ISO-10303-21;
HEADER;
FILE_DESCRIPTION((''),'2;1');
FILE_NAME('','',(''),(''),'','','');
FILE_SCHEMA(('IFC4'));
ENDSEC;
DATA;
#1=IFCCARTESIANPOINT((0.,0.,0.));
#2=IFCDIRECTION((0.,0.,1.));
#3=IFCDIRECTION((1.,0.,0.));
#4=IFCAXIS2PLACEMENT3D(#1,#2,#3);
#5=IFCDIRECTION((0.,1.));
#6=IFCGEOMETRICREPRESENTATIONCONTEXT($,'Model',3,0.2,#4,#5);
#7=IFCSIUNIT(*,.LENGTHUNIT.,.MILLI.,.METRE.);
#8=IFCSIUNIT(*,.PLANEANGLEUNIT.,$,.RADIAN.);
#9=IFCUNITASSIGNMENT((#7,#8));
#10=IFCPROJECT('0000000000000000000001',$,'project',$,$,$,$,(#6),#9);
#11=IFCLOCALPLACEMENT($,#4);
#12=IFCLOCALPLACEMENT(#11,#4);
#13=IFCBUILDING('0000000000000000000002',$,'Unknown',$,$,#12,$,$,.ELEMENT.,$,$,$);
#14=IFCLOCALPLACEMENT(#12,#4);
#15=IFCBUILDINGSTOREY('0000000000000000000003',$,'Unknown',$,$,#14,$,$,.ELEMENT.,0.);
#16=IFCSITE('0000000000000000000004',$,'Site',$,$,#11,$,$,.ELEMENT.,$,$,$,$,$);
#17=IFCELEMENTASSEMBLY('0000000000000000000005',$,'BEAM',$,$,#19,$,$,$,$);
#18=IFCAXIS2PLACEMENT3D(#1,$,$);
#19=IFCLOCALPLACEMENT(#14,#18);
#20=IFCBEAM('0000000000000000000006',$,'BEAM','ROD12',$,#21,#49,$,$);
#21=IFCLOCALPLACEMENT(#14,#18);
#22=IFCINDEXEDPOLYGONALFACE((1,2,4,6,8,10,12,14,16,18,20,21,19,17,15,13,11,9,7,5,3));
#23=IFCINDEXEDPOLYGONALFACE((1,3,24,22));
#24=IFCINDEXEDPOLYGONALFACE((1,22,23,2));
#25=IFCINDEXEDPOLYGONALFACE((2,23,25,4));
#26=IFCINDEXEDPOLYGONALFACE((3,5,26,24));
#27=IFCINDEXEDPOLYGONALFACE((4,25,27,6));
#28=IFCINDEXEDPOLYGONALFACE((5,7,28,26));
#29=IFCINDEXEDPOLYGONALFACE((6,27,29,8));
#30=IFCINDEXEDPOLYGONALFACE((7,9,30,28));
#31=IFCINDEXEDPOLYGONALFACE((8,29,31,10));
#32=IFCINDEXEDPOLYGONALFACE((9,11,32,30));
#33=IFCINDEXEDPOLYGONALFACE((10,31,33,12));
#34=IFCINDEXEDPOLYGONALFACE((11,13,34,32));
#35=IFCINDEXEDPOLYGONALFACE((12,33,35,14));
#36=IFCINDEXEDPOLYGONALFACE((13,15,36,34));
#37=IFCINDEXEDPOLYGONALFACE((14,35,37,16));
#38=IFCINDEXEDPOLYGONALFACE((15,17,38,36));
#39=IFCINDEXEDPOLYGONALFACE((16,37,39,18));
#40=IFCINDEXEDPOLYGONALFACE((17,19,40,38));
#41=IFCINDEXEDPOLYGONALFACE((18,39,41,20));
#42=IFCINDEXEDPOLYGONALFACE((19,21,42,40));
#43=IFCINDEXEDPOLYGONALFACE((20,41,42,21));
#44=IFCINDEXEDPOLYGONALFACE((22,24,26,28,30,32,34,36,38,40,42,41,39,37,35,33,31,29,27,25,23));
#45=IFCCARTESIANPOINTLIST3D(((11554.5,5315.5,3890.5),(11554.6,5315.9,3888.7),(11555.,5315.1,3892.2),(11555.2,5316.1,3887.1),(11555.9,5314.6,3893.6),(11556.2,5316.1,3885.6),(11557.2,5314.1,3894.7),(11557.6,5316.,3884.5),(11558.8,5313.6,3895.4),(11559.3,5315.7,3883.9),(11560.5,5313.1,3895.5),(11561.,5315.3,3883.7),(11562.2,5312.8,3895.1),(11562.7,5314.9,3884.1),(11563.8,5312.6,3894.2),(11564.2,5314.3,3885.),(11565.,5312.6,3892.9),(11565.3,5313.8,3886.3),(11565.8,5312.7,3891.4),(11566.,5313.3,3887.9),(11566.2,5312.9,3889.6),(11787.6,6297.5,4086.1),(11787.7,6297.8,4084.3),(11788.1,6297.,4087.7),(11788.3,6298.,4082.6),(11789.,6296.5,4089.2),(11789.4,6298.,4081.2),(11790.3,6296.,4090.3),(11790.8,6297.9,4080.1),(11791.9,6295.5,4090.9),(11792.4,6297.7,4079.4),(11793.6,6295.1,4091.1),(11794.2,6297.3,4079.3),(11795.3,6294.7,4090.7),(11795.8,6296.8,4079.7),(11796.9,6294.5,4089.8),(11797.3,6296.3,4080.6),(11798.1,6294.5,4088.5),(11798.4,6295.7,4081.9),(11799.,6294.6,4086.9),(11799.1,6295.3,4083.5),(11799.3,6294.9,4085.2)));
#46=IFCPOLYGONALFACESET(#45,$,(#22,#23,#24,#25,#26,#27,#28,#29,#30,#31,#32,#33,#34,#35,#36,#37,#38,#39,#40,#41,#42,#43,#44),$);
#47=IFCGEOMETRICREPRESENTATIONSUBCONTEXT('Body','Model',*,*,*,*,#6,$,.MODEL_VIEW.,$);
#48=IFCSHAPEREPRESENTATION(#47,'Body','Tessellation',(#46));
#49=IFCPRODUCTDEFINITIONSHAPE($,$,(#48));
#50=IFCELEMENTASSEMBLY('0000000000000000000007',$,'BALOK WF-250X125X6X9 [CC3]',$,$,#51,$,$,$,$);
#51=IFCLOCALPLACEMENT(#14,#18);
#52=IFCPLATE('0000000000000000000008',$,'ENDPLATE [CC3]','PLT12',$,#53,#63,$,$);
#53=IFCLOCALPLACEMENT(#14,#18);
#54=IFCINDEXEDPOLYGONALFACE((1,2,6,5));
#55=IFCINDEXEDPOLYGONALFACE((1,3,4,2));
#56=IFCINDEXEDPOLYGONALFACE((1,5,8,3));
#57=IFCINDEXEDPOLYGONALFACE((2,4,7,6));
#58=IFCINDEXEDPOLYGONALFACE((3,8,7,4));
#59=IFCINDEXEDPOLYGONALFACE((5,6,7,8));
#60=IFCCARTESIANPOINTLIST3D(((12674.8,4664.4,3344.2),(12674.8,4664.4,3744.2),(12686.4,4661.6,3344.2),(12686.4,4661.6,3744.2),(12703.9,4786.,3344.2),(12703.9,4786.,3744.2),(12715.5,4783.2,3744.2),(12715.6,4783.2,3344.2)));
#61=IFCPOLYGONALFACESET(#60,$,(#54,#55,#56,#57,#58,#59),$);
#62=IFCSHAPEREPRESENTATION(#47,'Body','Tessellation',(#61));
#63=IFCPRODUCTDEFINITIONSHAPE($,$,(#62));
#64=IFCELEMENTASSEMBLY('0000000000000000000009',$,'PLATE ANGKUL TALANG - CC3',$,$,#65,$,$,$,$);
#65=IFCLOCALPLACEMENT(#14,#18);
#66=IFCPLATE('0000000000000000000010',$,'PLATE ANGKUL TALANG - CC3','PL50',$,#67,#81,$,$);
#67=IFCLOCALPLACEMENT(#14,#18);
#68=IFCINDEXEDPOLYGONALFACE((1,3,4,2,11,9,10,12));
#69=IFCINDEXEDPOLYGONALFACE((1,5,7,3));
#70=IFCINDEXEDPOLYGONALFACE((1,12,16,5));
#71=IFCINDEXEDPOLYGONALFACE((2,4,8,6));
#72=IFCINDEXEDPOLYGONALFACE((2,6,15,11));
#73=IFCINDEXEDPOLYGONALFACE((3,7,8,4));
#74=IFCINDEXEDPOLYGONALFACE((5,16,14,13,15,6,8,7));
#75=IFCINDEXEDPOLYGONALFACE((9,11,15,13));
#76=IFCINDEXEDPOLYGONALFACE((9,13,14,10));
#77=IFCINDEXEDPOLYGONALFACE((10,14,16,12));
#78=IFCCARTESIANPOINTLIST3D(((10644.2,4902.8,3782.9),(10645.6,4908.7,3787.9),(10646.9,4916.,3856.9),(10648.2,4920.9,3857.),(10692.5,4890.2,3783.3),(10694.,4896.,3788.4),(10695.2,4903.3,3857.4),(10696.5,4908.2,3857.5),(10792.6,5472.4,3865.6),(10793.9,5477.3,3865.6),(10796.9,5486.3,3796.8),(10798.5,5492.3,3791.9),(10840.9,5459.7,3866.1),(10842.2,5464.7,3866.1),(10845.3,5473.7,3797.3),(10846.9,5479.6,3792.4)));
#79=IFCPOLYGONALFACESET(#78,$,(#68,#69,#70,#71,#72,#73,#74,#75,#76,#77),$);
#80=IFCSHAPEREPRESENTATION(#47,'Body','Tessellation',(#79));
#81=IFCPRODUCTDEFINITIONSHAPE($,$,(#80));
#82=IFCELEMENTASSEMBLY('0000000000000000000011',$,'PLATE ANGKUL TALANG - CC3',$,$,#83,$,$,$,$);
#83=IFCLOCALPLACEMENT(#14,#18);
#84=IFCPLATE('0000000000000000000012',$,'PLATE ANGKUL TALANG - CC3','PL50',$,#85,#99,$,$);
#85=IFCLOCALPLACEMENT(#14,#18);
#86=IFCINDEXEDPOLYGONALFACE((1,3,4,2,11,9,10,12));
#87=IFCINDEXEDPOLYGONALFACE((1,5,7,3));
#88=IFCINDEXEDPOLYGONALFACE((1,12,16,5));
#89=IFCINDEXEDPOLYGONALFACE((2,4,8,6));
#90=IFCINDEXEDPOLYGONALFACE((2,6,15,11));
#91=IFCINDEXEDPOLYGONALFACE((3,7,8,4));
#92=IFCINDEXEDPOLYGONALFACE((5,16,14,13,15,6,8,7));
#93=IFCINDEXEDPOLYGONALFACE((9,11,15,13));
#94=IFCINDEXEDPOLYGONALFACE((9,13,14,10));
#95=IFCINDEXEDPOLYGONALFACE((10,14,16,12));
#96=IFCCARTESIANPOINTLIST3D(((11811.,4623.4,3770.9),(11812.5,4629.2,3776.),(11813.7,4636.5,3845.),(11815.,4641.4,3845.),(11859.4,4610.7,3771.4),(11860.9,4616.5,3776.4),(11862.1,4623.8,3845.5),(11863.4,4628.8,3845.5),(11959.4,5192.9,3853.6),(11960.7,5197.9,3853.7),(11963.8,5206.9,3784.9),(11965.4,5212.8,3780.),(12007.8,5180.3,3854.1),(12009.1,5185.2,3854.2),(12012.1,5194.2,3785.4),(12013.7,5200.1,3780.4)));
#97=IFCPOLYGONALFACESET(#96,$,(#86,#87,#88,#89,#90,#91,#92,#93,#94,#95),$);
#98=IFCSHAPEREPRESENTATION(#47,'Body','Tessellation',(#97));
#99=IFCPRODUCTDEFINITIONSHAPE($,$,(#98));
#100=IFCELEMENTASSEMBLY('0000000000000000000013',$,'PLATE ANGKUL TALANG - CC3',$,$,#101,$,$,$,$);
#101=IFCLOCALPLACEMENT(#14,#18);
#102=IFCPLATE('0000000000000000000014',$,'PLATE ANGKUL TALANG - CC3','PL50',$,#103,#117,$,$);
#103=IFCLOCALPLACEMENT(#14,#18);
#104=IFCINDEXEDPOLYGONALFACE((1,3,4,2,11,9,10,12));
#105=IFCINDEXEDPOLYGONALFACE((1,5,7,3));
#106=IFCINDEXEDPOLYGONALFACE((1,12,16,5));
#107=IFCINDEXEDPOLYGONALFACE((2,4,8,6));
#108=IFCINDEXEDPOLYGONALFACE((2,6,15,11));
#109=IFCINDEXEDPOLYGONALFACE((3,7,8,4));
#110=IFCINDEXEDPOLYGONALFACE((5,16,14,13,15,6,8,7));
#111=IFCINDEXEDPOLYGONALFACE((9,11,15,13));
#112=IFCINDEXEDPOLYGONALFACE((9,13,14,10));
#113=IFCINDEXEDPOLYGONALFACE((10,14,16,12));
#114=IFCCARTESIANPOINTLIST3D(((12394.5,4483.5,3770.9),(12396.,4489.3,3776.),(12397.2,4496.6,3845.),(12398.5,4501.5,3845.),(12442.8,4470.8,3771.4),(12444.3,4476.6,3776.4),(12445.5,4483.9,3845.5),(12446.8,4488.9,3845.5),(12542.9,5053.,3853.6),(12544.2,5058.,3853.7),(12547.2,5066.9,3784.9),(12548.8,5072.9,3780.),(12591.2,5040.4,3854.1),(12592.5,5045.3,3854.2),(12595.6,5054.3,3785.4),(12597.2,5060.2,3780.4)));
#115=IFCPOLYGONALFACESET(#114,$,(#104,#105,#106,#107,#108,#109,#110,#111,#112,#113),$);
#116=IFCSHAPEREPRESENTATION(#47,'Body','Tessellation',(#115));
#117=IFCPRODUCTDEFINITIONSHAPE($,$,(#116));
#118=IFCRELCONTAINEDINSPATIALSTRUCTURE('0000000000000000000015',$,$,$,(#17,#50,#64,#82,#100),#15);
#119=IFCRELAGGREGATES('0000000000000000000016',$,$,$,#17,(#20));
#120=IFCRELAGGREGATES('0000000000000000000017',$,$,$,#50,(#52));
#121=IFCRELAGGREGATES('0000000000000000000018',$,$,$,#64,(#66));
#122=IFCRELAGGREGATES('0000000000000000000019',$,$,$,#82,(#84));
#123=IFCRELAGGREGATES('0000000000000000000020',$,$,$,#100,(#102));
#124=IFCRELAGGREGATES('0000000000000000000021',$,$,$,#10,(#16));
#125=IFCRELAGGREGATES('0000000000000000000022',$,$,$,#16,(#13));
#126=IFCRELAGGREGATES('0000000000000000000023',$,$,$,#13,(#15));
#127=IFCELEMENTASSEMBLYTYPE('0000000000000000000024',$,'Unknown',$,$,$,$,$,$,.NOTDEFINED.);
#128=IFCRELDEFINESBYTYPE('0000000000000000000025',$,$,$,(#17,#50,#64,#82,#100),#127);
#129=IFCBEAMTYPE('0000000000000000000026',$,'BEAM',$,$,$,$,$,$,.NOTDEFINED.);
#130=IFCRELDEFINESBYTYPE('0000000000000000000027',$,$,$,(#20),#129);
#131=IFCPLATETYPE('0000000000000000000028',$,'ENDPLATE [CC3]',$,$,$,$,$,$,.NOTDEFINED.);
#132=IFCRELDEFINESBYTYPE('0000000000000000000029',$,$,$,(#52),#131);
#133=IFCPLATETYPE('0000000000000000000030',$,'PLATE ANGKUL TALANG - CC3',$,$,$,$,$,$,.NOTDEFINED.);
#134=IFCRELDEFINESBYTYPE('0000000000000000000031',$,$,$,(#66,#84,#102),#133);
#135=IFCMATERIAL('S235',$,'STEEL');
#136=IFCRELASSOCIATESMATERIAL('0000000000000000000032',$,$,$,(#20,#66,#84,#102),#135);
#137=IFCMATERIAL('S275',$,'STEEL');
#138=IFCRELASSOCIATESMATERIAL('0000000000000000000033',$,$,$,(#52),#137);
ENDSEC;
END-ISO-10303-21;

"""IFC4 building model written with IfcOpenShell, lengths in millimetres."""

from ifc_helpers import new_model, si_unit, direction, frame, origin_with_axes, origin_2d_with_axis, place, context, subcontext, project, spatial, line, indexed_curve, circle, outline, extrude, material, material_profile, profile_set, profile_usage, type_object, element, aggregate, save


model = new_model("IFC4")

# Units and contexts
model_context = context("Model", 3, precision=0.2, world=origin_with_axes(), true_north=direction((0.0, 1.0)))
body_context = subcontext(model_context, "Body", "Model", "MODEL_VIEW")
ifc_project = project(units=[si_unit("LENGTHUNIT", "METRE", prefix="MILLI"), si_unit("PLANEANGLEUNIT", "RADIAN")], contexts=[model_context])

# Site, building, storey
site_placement = place(None, origin_with_axes())
site = spatial("IfcSite", under=ifc_project, at=site_placement, Name="Site", CompositionType="ELEMENT")
building_placement = place(site_placement, origin_with_axes())
building = spatial("IfcBuilding", under=site, at=building_placement, Name="Unknown", CompositionType="ELEMENT")
storey_placement = place(building_placement, origin_with_axes())
storey = spatial("IfcBuildingStorey", under=building, at=storey_placement, Name="Unknown", CompositionType="ELEMENT", Elevation=0.0)

# Element assembly, beam
element_assembly_type = type_object("IfcElementAssemblyType", Name="Unknown", PredefinedType="NOTDEFINED")
ifc_material_1 = material(Name="S235", Category="STEEL")
ifc_material_profile_1 = material_profile(ifc_material_1, circle(Radius=6.0, at=origin_2d_with_axis()), Name="ROD12")
ifc_profile_set_1 = profile_set([ifc_material_profile_1])
ifc_profile_usage_1 = profile_usage(ifc_profile_set_1, cardinal=5)
beam_type_1 = type_object("IfcBeamType", Name="BEAM", PredefinedType="NOTDEFINED")
assembly_1_placement = place(storey_placement, frame((11560.3, 5314.3, 3889.6), z_axis=(0.972955, -0.230997, 0.0), x_axis=(0.226778, 0.955184, 0.190249)))
assembly_1 = element("IfcElementAssembly", 1, at=assembly_1_placement, inside=storey, type_object=element_assembly_type, Name="BEAM")
beam_1_placement = place(assembly_1_placement, origin_with_axes())
beam_1 = element("IfcBeam", 2, at=beam_1_placement, type_object=beam_type_1, material=ifc_profile_usage_1, Name="BEAM", Description="ROD12", context=body_context, shape_type="SolidModel", body=[
    extrude(circle(Radius=6.0, at=origin_2d_with_axis()), frame((0.0, 0.0, 0.0), z_axis=(-1.0, 0.0, 0.0), x_axis=(0.0, 0.0, 1.0)), (0.0, 0.0, -1.0), 1028.0),
])
aggregate(assembly_1, [beam_1])

# Element assembly, plate
assembly_2_placement = place(storey_placement, frame((7427.6, 5985.4, 3619.2), z_axis=(-0.232926, -0.972495, 0.0), x_axis=(0.972495, -0.232926, 0.0)))
assembly_2 = element("IfcElementAssembly", 3, at=assembly_2_placement, inside=storey, type_object=element_assembly_type, Name="BALOK WF-250X125X6X9 [CC3]")
ifc_material_2 = material(Name="S275", Category="STEEL")
ifc_material_profile_2 = material_profile(ifc_material_2, outline(indexed_curve([(0.0, 0.0), (125.0, 0.0), (125.0, 400.0), (0.0, 400.0)], segments=[line(1, 2, 3, 4, 1)])), Name="PLT12")
ifc_profile_set_2 = profile_set([ifc_material_profile_2])
ifc_profile_usage_2 = profile_usage(ifc_profile_set_2, cardinal=5)
plate_type_1 = type_object("IfcPlateType", Name="ENDPLATE [CC3]", PredefinedType="NOTDEFINED")
plate_1_placement = place(assembly_2_placement, frame((5416.5, 125.0, -62.5), z_axis=(1.0, 0.000036, -0.000101), x_axis=(0.000101, -0.00003, 1.0)))
plate_1 = element("IfcPlate", 4, at=plate_1_placement, type_object=plate_type_1, material=ifc_profile_usage_2, Name="ENDPLATE [CC3]", Description="PLT12", context=body_context, shape_type="SolidModel", body=[
    extrude(outline(indexed_curve([(0.0, 0.0), (125.0, 0.0), (125.0, 400.0), (0.0, 400.0)], segments=[line(1, 2, 3, 4, 1)])), frame((0.0, 0.0, 6.0), z_axis=(0.0, 0.0, 1.0), x_axis=(1.0, 0.0, 0.0)), (0.0, 0.0, -1.0), 12.0),
])
aggregate(assembly_2, [plate_1])

# Element assemblies, plates
assembly_3_placement = place(storey_placement, frame((10818.0, 5471.0, 3865.9), z_axis=(-0.967302, 0.253442, -0.009723), x_axis=(0.061736, 0.198097, -0.978236)))
assembly_3 = element("IfcElementAssembly", 5, at=assembly_3_placement, inside=storey, type_object=element_assembly_type, Name="PLATE ANGKUL TALANG - CC3")
ifc_material_profile_3 = material_profile(ifc_material_1, outline(indexed_curve([(0.0, 0.0), (75.4, 0.0), (-42.1, 598.0), (-111.8, 569.5), (-110.8, 564.5), (-45.8, 591.0), (69.3, 5.0), (-1.0, 5.0)], segments=[line(1, 2, 3, 4, 5, 6, 7, 8, 1)])), Name="PL50")
ifc_profile_set_3 = profile_set([ifc_material_profile_3])
ifc_profile_usage_3 = profile_usage(ifc_profile_set_3, cardinal=5)
plate_type_2 = type_object("IfcPlateType", Name="PLATE ANGKUL TALANG - CC3", PredefinedType="NOTDEFINED")
plate_2_placement = place(assembly_3_placement, origin_with_axes())
plate_2 = element("IfcPlate", 6, at=plate_2_placement, type_object=plate_type_2, material=ifc_profile_usage_3, Name="PLATE ANGKUL TALANG - CC3", Description="PL50", context=body_context, shape_type="SolidModel", body=[
    extrude(outline(indexed_curve([(0.0, 0.0), (75.4, 0.0), (-42.1, 598.0), (-111.8, 569.5), (-110.8, 564.5), (-45.8, 591.0), (69.3, 5.0), (-1.0, 5.0)], segments=[line(1, 2, 3, 4, 5, 6, 7, 8, 1)])), frame((0.0, 0.0, 25.0), z_axis=(0.0, 0.0, 1.0), x_axis=(1.0, 0.0, 0.0)), (0.0, 0.0, -1.0), 50.0),
])
aggregate(assembly_3, [plate_2])
assembly_4_placement = place(storey_placement, frame((11984.9, 5191.5, 3853.9), z_axis=(-0.967302, 0.253442, -0.009723), x_axis=(0.061736, 0.198097, -0.978236)))
assembly_4 = element("IfcElementAssembly", 7, at=assembly_4_placement, inside=storey, type_object=element_assembly_type, Name="PLATE ANGKUL TALANG - CC3")
plate_3_placement = place(assembly_4_placement, origin_with_axes())
plate_3 = element("IfcPlate", 8, at=plate_3_placement, type_object=plate_type_2, material=ifc_profile_usage_3, Name="PLATE ANGKUL TALANG - CC3", Description="PL50", context=body_context, shape_type="SolidModel", body=[
    extrude(outline(indexed_curve([(0.0, 0.0), (75.4, 0.0), (-42.1, 598.0), (-111.8, 569.5), (-110.8, 564.5), (-45.8, 591.0), (69.3, 5.0), (-1.0, 5.0)], segments=[line(1, 2, 3, 4, 5, 6, 7, 8, 1)])), frame((0.0, 0.0, 25.0), z_axis=(0.0, 0.0, 1.0), x_axis=(1.0, 0.0, 0.0)), (0.0, 0.0, -1.0), 50.0),
])
aggregate(assembly_4, [plate_3])
assembly_5_placement = place(storey_placement, frame((12568.4, 5051.6, 3853.9), z_axis=(-0.967302, 0.253442, -0.009723), x_axis=(0.061736, 0.198097, -0.978236)))
assembly_5 = element("IfcElementAssembly", 9, at=assembly_5_placement, inside=storey, type_object=element_assembly_type, Name="PLATE ANGKUL TALANG - CC3")
plate_4_placement = place(assembly_5_placement, origin_with_axes())
plate_4 = element("IfcPlate", 10, at=plate_4_placement, type_object=plate_type_2, material=ifc_profile_usage_3, Name="PLATE ANGKUL TALANG - CC3", Description="PL50", context=body_context, shape_type="SolidModel", body=[
    extrude(outline(indexed_curve([(0.0, 0.0), (75.4, 0.0), (-42.1, 598.0), (-111.8, 569.5), (-110.8, 564.5), (-45.8, 591.0), (69.3, 5.0), (-1.0, 5.0)], segments=[line(1, 2, 3, 4, 5, 6, 7, 8, 1)])), frame((0.0, 0.0, 25.0), z_axis=(0.0, 0.0, 1.0), x_axis=(1.0, 0.0, 0.0)), (0.0, 0.0, -1.0), 50.0),
])
aggregate(assembly_5, [plate_4])

save(model, "model.ifc")
